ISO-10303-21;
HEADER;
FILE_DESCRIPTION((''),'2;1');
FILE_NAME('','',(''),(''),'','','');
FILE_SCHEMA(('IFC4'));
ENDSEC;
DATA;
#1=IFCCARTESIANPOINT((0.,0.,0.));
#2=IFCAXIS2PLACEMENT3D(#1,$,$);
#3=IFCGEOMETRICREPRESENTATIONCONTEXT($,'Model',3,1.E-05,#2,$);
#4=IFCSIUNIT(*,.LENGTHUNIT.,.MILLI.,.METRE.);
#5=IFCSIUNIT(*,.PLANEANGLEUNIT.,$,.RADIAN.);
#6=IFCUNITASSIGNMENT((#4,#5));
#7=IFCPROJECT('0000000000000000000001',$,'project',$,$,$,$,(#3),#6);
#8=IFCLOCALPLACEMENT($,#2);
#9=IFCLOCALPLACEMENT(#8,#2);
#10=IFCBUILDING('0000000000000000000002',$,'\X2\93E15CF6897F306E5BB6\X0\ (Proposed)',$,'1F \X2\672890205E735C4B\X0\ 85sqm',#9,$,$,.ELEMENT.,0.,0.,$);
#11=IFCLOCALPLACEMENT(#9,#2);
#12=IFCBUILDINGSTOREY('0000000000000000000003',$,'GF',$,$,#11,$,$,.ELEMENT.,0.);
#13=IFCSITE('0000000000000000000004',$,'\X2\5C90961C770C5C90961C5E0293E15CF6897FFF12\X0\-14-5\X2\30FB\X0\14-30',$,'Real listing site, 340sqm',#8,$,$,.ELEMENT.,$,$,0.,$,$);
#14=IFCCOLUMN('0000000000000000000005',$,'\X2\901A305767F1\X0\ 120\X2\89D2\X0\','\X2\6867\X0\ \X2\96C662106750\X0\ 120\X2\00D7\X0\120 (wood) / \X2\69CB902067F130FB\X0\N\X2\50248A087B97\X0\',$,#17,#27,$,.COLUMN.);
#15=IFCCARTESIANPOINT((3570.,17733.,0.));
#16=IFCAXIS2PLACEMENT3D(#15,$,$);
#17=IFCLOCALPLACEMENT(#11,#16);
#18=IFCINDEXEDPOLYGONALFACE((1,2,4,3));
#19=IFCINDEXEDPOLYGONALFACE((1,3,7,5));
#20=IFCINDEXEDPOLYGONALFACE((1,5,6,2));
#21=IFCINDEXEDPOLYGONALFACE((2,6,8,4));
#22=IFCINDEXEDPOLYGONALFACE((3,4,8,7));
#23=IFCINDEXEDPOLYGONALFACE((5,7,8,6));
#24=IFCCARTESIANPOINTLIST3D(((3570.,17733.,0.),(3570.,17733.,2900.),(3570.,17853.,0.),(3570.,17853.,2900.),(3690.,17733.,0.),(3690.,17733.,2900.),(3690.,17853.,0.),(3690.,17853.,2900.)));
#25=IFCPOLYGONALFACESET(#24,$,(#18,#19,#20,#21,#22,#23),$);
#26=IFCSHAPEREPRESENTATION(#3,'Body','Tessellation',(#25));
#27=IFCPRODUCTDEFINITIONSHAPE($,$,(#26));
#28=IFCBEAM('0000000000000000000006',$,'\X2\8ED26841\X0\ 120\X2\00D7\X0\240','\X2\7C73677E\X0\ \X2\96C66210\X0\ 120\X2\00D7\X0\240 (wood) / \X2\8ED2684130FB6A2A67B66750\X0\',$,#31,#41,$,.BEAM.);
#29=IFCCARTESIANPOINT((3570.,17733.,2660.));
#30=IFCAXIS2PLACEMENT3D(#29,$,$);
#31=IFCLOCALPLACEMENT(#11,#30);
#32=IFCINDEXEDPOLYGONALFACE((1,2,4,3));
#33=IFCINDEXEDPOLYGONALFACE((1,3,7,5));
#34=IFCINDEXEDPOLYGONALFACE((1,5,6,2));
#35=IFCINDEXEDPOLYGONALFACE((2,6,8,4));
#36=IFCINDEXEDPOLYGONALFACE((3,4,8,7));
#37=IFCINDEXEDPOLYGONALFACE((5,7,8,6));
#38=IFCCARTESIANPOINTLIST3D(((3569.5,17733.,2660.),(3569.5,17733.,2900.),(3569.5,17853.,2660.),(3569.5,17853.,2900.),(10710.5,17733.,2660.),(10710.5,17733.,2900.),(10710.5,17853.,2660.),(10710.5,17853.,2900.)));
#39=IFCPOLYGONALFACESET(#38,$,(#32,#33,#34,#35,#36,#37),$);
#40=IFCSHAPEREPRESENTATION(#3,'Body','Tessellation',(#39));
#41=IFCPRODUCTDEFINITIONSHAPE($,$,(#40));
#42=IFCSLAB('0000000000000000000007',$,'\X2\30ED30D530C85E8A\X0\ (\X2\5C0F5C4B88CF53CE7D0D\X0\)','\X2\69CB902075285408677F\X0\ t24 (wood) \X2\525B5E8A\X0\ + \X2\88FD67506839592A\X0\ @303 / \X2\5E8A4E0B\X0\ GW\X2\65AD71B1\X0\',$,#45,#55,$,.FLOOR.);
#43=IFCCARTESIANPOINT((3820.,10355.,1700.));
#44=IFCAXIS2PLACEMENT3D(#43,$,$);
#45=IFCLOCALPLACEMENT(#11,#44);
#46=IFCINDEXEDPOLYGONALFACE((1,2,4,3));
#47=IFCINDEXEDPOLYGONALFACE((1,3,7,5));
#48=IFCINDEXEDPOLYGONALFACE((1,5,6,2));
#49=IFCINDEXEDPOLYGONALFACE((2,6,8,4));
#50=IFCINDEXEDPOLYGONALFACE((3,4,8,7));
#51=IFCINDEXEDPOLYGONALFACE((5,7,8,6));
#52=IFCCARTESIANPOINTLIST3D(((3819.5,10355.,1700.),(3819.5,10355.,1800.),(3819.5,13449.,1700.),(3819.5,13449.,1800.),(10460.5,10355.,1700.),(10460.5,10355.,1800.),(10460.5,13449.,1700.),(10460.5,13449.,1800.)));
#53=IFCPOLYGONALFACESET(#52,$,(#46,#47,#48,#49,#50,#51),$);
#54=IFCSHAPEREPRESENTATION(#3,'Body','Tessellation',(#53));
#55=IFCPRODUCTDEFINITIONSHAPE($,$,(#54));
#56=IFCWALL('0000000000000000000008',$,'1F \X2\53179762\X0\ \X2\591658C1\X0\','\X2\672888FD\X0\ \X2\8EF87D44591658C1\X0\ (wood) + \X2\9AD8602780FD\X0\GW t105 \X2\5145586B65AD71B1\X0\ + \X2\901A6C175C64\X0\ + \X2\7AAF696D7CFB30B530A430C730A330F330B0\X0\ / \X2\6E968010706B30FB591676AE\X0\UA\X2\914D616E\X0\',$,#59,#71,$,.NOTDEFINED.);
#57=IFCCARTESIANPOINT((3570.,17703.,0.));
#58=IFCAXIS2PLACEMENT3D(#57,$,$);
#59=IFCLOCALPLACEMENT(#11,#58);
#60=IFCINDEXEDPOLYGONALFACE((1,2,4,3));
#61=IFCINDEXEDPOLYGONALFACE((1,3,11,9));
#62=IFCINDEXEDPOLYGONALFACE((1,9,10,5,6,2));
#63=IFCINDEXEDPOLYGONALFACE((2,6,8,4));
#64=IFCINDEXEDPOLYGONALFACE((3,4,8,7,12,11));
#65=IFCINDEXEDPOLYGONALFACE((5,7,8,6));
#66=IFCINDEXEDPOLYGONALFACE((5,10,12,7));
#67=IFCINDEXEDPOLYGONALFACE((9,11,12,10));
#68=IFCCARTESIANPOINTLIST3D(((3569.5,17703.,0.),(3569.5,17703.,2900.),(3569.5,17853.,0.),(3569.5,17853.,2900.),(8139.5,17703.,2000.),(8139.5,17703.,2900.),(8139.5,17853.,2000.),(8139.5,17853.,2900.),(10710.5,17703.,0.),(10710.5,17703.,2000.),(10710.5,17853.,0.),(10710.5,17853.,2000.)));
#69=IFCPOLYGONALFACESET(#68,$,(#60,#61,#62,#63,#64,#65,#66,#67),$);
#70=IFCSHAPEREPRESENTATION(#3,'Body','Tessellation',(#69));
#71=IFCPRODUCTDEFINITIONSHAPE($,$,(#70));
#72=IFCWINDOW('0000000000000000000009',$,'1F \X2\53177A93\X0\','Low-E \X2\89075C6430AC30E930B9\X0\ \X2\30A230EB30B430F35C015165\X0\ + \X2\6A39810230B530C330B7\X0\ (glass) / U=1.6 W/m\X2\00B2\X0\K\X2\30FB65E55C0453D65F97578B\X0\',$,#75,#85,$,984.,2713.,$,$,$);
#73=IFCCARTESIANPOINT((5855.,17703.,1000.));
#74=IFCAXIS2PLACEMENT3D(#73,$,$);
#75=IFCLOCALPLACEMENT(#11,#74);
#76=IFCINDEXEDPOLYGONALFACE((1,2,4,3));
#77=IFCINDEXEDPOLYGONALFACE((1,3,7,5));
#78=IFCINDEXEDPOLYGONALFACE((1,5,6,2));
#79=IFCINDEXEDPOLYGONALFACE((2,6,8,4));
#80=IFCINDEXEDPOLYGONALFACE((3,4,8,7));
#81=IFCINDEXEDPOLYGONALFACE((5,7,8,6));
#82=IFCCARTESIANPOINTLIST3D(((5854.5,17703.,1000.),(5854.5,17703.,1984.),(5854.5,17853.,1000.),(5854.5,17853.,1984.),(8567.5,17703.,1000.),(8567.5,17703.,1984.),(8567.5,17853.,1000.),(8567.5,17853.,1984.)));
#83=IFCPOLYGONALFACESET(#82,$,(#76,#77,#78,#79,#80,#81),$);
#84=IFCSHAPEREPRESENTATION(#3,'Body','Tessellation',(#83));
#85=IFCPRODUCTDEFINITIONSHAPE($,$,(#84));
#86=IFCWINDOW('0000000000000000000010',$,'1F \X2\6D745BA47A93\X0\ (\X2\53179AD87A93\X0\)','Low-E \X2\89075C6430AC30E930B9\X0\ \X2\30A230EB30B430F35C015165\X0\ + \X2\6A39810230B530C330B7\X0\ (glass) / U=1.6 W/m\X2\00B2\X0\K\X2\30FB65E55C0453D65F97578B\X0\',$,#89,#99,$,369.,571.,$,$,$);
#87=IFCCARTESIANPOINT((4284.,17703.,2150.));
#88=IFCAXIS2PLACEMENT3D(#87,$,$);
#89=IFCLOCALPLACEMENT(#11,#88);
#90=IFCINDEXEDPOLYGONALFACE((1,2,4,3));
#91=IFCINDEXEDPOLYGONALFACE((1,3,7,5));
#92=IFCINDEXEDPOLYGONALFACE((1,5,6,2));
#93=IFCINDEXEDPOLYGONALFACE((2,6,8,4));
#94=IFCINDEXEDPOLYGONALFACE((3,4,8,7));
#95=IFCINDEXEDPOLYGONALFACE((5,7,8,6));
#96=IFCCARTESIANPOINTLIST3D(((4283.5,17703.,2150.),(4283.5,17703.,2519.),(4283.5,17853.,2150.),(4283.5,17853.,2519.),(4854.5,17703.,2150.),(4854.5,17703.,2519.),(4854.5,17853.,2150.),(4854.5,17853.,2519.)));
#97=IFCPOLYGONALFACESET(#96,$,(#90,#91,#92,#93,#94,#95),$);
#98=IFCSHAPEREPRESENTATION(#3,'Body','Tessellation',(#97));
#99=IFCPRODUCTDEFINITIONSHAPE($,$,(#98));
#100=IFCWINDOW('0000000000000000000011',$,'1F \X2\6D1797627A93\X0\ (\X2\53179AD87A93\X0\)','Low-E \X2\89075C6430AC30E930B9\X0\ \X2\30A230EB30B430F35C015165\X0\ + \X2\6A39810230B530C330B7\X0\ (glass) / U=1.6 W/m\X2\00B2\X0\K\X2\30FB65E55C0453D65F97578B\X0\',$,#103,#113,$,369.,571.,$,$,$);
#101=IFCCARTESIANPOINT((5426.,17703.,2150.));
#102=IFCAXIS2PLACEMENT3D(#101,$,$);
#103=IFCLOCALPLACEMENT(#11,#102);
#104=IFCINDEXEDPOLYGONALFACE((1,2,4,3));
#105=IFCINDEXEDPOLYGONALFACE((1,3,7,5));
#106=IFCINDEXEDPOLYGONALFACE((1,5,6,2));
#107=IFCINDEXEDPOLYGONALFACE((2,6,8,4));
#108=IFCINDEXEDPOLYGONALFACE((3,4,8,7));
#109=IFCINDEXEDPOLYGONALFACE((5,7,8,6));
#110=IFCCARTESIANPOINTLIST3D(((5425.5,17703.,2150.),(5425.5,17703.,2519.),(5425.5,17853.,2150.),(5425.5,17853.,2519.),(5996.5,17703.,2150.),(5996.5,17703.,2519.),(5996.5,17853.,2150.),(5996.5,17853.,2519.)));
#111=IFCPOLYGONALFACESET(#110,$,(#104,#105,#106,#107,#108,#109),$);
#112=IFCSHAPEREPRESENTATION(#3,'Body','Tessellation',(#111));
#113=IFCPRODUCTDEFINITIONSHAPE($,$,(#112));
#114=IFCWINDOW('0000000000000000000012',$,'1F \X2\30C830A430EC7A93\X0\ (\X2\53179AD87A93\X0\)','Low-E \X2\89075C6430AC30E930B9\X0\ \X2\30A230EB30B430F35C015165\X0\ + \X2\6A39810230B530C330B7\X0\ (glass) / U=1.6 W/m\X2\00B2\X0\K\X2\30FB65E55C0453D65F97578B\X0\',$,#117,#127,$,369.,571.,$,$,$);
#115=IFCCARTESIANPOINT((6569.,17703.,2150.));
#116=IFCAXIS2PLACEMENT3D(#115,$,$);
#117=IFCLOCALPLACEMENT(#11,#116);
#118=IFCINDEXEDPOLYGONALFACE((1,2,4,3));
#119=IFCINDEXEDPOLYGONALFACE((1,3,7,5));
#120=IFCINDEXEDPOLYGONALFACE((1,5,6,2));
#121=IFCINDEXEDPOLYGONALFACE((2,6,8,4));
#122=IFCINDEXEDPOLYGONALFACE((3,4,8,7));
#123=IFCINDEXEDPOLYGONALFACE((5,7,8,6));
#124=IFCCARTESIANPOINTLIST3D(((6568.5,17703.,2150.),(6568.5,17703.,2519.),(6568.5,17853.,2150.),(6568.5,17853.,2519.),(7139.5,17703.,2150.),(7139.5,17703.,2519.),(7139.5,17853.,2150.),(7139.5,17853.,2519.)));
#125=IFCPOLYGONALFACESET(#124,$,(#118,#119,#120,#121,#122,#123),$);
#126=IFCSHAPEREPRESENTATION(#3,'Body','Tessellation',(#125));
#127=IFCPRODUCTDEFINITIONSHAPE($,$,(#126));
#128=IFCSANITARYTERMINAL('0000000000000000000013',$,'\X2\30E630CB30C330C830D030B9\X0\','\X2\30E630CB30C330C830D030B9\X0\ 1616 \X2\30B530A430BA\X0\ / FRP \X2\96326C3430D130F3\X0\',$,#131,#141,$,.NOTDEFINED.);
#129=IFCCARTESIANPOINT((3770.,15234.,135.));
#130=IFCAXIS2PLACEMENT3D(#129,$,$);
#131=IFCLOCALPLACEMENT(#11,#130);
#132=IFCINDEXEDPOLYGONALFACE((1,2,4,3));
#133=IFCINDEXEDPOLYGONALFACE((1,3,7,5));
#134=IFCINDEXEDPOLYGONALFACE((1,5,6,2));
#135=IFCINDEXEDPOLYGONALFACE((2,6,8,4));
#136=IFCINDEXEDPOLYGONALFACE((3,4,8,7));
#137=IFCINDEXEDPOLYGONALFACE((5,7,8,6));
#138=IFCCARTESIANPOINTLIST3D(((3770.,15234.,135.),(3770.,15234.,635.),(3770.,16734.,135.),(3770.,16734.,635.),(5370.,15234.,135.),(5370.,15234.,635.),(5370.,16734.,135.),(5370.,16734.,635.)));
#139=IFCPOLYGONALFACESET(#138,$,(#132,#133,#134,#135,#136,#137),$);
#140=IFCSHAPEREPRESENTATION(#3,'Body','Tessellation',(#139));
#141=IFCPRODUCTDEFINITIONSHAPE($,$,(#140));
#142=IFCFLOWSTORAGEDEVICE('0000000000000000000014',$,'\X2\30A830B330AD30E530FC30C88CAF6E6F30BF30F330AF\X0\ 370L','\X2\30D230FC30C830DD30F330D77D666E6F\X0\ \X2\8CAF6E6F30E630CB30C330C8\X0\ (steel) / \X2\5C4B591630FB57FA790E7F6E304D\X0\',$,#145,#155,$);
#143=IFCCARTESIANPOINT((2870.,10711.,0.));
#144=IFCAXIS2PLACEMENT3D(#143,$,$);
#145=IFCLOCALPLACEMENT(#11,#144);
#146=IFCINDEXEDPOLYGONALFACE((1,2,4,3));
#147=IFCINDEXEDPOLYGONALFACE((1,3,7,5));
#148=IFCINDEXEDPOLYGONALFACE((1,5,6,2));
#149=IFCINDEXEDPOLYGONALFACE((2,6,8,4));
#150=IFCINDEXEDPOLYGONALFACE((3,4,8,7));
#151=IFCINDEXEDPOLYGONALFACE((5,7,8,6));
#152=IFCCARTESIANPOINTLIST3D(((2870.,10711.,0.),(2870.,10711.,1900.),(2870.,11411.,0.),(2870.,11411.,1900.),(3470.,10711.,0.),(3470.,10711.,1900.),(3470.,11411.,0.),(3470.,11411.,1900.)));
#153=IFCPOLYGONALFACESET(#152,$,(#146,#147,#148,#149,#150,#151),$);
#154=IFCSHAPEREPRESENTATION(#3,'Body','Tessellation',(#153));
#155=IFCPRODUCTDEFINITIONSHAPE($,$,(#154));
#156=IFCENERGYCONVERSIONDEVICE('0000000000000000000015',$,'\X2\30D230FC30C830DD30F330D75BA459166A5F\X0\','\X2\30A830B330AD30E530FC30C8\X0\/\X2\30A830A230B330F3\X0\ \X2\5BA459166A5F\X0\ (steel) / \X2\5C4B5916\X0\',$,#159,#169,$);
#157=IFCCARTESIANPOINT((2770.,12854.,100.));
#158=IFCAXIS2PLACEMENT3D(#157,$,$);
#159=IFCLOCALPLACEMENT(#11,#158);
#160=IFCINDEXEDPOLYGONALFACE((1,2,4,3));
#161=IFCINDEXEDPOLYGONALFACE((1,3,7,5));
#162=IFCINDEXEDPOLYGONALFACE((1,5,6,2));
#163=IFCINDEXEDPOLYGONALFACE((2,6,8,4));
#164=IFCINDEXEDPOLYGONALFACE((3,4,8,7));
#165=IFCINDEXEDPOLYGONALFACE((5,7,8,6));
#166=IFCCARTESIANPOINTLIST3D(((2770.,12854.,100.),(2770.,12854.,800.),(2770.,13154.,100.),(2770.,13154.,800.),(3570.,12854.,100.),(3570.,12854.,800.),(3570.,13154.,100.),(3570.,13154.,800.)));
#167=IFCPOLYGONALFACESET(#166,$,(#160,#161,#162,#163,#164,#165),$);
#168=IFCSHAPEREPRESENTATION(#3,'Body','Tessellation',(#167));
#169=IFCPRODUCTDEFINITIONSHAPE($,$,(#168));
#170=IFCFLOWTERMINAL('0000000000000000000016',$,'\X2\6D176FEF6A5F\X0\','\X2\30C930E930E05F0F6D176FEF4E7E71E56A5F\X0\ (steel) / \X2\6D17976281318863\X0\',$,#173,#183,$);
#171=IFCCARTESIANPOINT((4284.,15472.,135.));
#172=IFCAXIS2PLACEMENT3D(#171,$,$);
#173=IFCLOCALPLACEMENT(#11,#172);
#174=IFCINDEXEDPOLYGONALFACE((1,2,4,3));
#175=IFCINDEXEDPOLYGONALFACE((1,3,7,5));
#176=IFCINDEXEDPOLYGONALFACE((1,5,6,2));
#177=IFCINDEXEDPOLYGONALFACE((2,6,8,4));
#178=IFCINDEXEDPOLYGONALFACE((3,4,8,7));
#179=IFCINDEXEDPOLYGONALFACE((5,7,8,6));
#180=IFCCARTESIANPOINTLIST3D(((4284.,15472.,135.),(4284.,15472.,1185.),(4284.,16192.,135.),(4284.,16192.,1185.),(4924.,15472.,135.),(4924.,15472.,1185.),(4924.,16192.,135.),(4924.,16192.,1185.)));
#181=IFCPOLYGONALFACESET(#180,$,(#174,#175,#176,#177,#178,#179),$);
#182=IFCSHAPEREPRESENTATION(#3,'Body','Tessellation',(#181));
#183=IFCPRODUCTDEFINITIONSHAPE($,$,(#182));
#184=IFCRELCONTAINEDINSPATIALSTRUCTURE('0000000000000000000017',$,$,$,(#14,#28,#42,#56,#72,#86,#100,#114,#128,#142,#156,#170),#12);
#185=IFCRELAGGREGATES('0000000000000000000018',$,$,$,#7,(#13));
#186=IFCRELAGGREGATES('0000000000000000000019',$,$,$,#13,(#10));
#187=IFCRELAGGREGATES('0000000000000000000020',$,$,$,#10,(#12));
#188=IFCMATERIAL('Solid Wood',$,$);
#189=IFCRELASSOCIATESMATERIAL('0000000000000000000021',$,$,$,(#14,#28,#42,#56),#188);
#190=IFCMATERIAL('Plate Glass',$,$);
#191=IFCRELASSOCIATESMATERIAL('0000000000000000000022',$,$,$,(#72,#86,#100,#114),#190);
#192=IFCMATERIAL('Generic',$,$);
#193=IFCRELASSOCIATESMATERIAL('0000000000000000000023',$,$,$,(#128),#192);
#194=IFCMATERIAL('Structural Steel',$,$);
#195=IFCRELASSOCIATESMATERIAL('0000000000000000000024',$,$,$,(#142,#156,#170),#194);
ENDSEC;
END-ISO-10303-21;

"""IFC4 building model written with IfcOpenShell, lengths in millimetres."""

from ifc_helpers import new_model, si_unit, frame, frame_2d, origin, place, context, project, spatial, rectangle, extrude, material, element, fill, save


model = new_model("IFC4")

# Units and contexts
model_context = context("Model", 3, precision=1e-05, world=origin())
ifc_project = project(units=[si_unit("LENGTHUNIT", "METRE", prefix="MILLI"), si_unit("PLANEANGLEUNIT", "RADIAN")], contexts=[model_context])

# Site, building, storey
site_placement = place(None, origin())
site = spatial("IfcSite", under=ifc_project, at=site_placement, Name="岐阜県岐阜市鏡島西２-14-5・14-30", ObjectType="Real listing site, 340sqm", CompositionType="ELEMENT", RefElevation=0.0)
building_placement = place(site_placement, origin())
building = spatial("IfcBuilding", under=site, at=building_placement, Name="鏡島西の家 (Proposed)", ObjectType="1F 木造平屋 85sqm", CompositionType="ELEMENT", ElevationOfRefHeight=0.0, ElevationOfTerrain=0.0)
storey_placement = place(building_placement, origin())
storey = spatial("IfcBuildingStorey", under=building, at=storey_placement, Name="GF", CompositionType="ELEMENT", Elevation=0.0)

# Column
ifc_material_1 = material(Name="Solid Wood")
column_1_placement = place(storey_placement, frame((3570.0, 17733.0, 0.0)))
element("IfcColumn", 1, at=column_1_placement, inside=storey, material=ifc_material_1, Name="通し柱 120角", Description="桧 集成材 120×120 (wood) / 構造柱・N値計算", PredefinedType="COLUMN", context=model_context, shape_type="SweptSolid", body=[
    extrude(rectangle(XDim=120.0, YDim=120.0, at=frame_2d((60.0, 60.0))), frame((3570.0, 17733.0, 0.0)), (0.0, 0.0, 1.0), 2900.0),
])

# Beam
beam_1_placement = place(storey_placement, frame((3570.0, 17733.0, 2660.0)))
element("IfcBeam", 2, at=beam_1_placement, inside=storey, material=ifc_material_1, Name="軒桁 120×240", Description="米松 集成 120×240 (wood) / 軒桁・横架材", PredefinedType="BEAM", context=model_context, shape_type="SweptSolid", body=[
    extrude(rectangle(XDim=7141.0, YDim=120.0, at=frame_2d((3570.0, 60.0))), frame((3570.0, 17733.0, 2660.0)), (0.0, 0.0, 1.0), 240.0),
])

# Slab
slab_placement = place(storey_placement, frame((3820.0, 10355.0, 1700.0)))
element("IfcSlab", 3, at=slab_placement, inside=storey, material=ifc_material_1, Name="ロフト床 (小屋裏収納)", Description="構造用合板 t24 (wood) 剛床 + 製材根太 @303 / 床下 GW断熱", PredefinedType="FLOOR", context=model_context, shape_type="SweptSolid", body=[
    extrude(rectangle(XDim=6641.0, YDim=3094.0, at=frame_2d((3320.0, 1547.0))), frame((3820.0, 10355.0, 1700.0)), (0.0, 0.0, 1.0), 100.0),
])

# Wall, openings, windows
wall_1_placement = place(storey_placement, frame((3570.0, 17703.0, 0.0)))
wall_1 = element("IfcWall", 4, at=wall_1_placement, inside=storey, material=ifc_material_1, Name="1F 北面 外壁", Description="木製 軸組外壁 (wood) + 高性能GW t105 充填断熱 + 通気層 + 窯業系サイディング / 準耐火・外皮UA配慮", PredefinedType="NOTDEFINED", context=model_context, shape_type="SweptSolid", body=[
    extrude(rectangle(XDim=7141.0, YDim=150.0, at=frame_2d((3570.0, 75.0))), frame((3570.0, 17703.0, 0.0)), (0.0, 0.0, 1.0), 2900.0),
])
opening_1_placement = place(storey_placement, frame((5855.0, 17703.0, 1000.0)))
opening_1 = element("IfcOpeningElement", 5, at=opening_1_placement, cuts=wall_1, PredefinedType="NOTDEFINED", context=model_context, shape_type="SweptSolid", body=[
    extrude(rectangle(XDim=2713.0, YDim=150.0, at=frame_2d((1356.0, 75.0))), frame((5855.0, 17703.0, 1000.0)), (0.0, 0.0, 1.0), 984.0),
])
opening_2_placement = place(storey_placement, frame((4284.0, 17703.0, 2150.0)))
opening_2 = element("IfcOpeningElement", 6, at=opening_2_placement, cuts=wall_1, PredefinedType="NOTDEFINED", context=model_context, shape_type="SweptSolid", body=[
    extrude(rectangle(XDim=571.0, YDim=150.0, at=frame_2d((285.0, 75.0))), frame((4284.0, 17703.0, 2150.0)), (0.0, 0.0, 1.0), 369.0),
])
opening_3_placement = place(storey_placement, frame((5426.0, 17703.0, 2150.0)))
opening_3 = element("IfcOpeningElement", 7, at=opening_3_placement, cuts=wall_1, PredefinedType="NOTDEFINED", context=model_context, shape_type="SweptSolid", body=[
    extrude(rectangle(XDim=571.0, YDim=150.0, at=frame_2d((285.0, 75.0))), frame((5426.0, 17703.0, 2150.0)), (0.0, 0.0, 1.0), 369.0),
])
opening_4_placement = place(storey_placement, frame((6569.0, 17703.0, 2150.0)))
opening_4 = element("IfcOpeningElement", 8, at=opening_4_placement, cuts=wall_1, PredefinedType="NOTDEFINED", context=model_context, shape_type="SweptSolid", body=[
    extrude(rectangle(XDim=571.0, YDim=150.0, at=frame_2d((285.0, 75.0))), frame((6569.0, 17703.0, 2150.0)), (0.0, 0.0, 1.0), 369.0),
])
ifc_material_2 = material(Name="Plate Glass")
window_1_placement = place(storey_placement, frame((5855.0, 17703.0, 1000.0)))
window_1 = element("IfcWindow", 9, at=window_1_placement, inside=storey, material=ifc_material_2, Name="1F 北窓", Description="Low-E 複層ガラス アルゴン封入 + 樹脂サッシ (glass) / U=1.6 W/m²K・日射取得型", OverallHeight=984.0, OverallWidth=2713.0, context=model_context, shape_type="SweptSolid", body=[
    extrude(rectangle(XDim=2713.0, YDim=150.0, at=frame_2d((1356.0, 75.0))), frame((5855.0, 17703.0, 1000.0)), (0.0, 0.0, 1.0), 984.0),
])
fill(opening_1, window_1)
window_2_placement = place(storey_placement, frame((4284.0, 17703.0, 2150.0)))
window_2 = element("IfcWindow", 10, at=window_2_placement, inside=storey, material=ifc_material_2, Name="1F 浴室窓 (北高窓)", Description="Low-E 複層ガラス アルゴン封入 + 樹脂サッシ (glass) / U=1.6 W/m²K・日射取得型", OverallHeight=369.0, OverallWidth=571.0, context=model_context, shape_type="SweptSolid", body=[
    extrude(rectangle(XDim=571.0, YDim=150.0, at=frame_2d((285.0, 75.0))), frame((4284.0, 17703.0, 2150.0)), (0.0, 0.0, 1.0), 369.0),
])
fill(opening_2, window_2)
window_3_placement = place(storey_placement, frame((5426.0, 17703.0, 2150.0)))
window_3 = element("IfcWindow", 11, at=window_3_placement, inside=storey, material=ifc_material_2, Name="1F 洗面窓 (北高窓)", Description="Low-E 複層ガラス アルゴン封入 + 樹脂サッシ (glass) / U=1.6 W/m²K・日射取得型", OverallHeight=369.0, OverallWidth=571.0, context=model_context, shape_type="SweptSolid", body=[
    extrude(rectangle(XDim=571.0, YDim=150.0, at=frame_2d((285.0, 75.0))), frame((5426.0, 17703.0, 2150.0)), (0.0, 0.0, 1.0), 369.0),
])
fill(opening_3, window_3)
window_4_placement = place(storey_placement, frame((6569.0, 17703.0, 2150.0)))
window_4 = element("IfcWindow", 12, at=window_4_placement, inside=storey, material=ifc_material_2, Name="1F トイレ窓 (北高窓)", Description="Low-E 複層ガラス アルゴン封入 + 樹脂サッシ (glass) / U=1.6 W/m²K・日射取得型", OverallHeight=369.0, OverallWidth=571.0, context=model_context, shape_type="SweptSolid", body=[
    extrude(rectangle(XDim=571.0, YDim=150.0, at=frame_2d((285.0, 75.0))), frame((6569.0, 17703.0, 2150.0)), (0.0, 0.0, 1.0), 369.0),
])
fill(opening_4, window_4)

# Sanitary terminal
ifc_material_3 = material(Name="Generic")
sanitary_terminal_placement = place(storey_placement, frame((3770.0, 15234.0, 135.0)))
element("IfcSanitaryTerminal", 13, at=sanitary_terminal_placement, inside=storey, material=ifc_material_3, Name="ユニットバス", Description="ユニットバス 1616 サイズ / FRP 防水パン", PredefinedType="NOTDEFINED", context=model_context, shape_type="SweptSolid", body=[
    extrude(rectangle(XDim=1600.0, YDim=1500.0, at=frame_2d((800.0, 750.0))), frame((3770.0, 15234.0, 135.0)), (0.0, 0.0, 1.0), 500.0),
])

# Flow storage device
ifc_material_4 = material(Name="Structural Steel")
flow_storage_device_placement = place(storey_placement, frame((2870.0, 10711.0, 0.0)))
element("IfcFlowStorageDevice", 14, at=flow_storage_device_placement, inside=storey, material=ifc_material_4, Name="エコキュート貯湯タンク 370L", Description="ヒートポンプ給湯 貯湯ユニット (steel) / 屋外・基礎置き", context=model_context, shape_type="SweptSolid", body=[
    extrude(rectangle(XDim=600.0, YDim=700.0, at=frame_2d((300.0, 350.0))), frame((2870.0, 10711.0, 0.0)), (0.0, 0.0, 1.0), 1900.0),
])

# Energy conversion device
energy_conversion_device_placement = place(storey_placement, frame((2770.0, 12854.0, 100.0)))
element("IfcEnergyConversionDevice", 15, at=energy_conversion_device_placement, inside=storey, material=ifc_material_4, Name="ヒートポンプ室外機", Description="エコキュート/エアコン 室外機 (steel) / 屋外", context=model_context, shape_type="SweptSolid", body=[
    extrude(rectangle(XDim=800.0, YDim=300.0, at=frame_2d((400.0, 150.0))), frame((2770.0, 12854.0, 100.0)), (0.0, 0.0, 1.0), 700.0),
])

# Flow terminal
flow_terminal_placement = place(storey_placement, frame((4284.0, 15472.0, 135.0)))
element("IfcFlowTerminal", 16, at=flow_terminal_placement, inside=storey, material=ifc_material_4, Name="洗濯機", Description="ドラム式洗濯乾燥機 (steel) / 洗面脱衣", context=model_context, shape_type="SweptSolid", body=[
    extrude(rectangle(XDim=640.0, YDim=720.0, at=frame_2d((320.0, 360.0))), frame((4284.0, 15472.0, 135.0)), (0.0, 0.0, 1.0), 1050.0),
])

save(model, "model.ifc")
